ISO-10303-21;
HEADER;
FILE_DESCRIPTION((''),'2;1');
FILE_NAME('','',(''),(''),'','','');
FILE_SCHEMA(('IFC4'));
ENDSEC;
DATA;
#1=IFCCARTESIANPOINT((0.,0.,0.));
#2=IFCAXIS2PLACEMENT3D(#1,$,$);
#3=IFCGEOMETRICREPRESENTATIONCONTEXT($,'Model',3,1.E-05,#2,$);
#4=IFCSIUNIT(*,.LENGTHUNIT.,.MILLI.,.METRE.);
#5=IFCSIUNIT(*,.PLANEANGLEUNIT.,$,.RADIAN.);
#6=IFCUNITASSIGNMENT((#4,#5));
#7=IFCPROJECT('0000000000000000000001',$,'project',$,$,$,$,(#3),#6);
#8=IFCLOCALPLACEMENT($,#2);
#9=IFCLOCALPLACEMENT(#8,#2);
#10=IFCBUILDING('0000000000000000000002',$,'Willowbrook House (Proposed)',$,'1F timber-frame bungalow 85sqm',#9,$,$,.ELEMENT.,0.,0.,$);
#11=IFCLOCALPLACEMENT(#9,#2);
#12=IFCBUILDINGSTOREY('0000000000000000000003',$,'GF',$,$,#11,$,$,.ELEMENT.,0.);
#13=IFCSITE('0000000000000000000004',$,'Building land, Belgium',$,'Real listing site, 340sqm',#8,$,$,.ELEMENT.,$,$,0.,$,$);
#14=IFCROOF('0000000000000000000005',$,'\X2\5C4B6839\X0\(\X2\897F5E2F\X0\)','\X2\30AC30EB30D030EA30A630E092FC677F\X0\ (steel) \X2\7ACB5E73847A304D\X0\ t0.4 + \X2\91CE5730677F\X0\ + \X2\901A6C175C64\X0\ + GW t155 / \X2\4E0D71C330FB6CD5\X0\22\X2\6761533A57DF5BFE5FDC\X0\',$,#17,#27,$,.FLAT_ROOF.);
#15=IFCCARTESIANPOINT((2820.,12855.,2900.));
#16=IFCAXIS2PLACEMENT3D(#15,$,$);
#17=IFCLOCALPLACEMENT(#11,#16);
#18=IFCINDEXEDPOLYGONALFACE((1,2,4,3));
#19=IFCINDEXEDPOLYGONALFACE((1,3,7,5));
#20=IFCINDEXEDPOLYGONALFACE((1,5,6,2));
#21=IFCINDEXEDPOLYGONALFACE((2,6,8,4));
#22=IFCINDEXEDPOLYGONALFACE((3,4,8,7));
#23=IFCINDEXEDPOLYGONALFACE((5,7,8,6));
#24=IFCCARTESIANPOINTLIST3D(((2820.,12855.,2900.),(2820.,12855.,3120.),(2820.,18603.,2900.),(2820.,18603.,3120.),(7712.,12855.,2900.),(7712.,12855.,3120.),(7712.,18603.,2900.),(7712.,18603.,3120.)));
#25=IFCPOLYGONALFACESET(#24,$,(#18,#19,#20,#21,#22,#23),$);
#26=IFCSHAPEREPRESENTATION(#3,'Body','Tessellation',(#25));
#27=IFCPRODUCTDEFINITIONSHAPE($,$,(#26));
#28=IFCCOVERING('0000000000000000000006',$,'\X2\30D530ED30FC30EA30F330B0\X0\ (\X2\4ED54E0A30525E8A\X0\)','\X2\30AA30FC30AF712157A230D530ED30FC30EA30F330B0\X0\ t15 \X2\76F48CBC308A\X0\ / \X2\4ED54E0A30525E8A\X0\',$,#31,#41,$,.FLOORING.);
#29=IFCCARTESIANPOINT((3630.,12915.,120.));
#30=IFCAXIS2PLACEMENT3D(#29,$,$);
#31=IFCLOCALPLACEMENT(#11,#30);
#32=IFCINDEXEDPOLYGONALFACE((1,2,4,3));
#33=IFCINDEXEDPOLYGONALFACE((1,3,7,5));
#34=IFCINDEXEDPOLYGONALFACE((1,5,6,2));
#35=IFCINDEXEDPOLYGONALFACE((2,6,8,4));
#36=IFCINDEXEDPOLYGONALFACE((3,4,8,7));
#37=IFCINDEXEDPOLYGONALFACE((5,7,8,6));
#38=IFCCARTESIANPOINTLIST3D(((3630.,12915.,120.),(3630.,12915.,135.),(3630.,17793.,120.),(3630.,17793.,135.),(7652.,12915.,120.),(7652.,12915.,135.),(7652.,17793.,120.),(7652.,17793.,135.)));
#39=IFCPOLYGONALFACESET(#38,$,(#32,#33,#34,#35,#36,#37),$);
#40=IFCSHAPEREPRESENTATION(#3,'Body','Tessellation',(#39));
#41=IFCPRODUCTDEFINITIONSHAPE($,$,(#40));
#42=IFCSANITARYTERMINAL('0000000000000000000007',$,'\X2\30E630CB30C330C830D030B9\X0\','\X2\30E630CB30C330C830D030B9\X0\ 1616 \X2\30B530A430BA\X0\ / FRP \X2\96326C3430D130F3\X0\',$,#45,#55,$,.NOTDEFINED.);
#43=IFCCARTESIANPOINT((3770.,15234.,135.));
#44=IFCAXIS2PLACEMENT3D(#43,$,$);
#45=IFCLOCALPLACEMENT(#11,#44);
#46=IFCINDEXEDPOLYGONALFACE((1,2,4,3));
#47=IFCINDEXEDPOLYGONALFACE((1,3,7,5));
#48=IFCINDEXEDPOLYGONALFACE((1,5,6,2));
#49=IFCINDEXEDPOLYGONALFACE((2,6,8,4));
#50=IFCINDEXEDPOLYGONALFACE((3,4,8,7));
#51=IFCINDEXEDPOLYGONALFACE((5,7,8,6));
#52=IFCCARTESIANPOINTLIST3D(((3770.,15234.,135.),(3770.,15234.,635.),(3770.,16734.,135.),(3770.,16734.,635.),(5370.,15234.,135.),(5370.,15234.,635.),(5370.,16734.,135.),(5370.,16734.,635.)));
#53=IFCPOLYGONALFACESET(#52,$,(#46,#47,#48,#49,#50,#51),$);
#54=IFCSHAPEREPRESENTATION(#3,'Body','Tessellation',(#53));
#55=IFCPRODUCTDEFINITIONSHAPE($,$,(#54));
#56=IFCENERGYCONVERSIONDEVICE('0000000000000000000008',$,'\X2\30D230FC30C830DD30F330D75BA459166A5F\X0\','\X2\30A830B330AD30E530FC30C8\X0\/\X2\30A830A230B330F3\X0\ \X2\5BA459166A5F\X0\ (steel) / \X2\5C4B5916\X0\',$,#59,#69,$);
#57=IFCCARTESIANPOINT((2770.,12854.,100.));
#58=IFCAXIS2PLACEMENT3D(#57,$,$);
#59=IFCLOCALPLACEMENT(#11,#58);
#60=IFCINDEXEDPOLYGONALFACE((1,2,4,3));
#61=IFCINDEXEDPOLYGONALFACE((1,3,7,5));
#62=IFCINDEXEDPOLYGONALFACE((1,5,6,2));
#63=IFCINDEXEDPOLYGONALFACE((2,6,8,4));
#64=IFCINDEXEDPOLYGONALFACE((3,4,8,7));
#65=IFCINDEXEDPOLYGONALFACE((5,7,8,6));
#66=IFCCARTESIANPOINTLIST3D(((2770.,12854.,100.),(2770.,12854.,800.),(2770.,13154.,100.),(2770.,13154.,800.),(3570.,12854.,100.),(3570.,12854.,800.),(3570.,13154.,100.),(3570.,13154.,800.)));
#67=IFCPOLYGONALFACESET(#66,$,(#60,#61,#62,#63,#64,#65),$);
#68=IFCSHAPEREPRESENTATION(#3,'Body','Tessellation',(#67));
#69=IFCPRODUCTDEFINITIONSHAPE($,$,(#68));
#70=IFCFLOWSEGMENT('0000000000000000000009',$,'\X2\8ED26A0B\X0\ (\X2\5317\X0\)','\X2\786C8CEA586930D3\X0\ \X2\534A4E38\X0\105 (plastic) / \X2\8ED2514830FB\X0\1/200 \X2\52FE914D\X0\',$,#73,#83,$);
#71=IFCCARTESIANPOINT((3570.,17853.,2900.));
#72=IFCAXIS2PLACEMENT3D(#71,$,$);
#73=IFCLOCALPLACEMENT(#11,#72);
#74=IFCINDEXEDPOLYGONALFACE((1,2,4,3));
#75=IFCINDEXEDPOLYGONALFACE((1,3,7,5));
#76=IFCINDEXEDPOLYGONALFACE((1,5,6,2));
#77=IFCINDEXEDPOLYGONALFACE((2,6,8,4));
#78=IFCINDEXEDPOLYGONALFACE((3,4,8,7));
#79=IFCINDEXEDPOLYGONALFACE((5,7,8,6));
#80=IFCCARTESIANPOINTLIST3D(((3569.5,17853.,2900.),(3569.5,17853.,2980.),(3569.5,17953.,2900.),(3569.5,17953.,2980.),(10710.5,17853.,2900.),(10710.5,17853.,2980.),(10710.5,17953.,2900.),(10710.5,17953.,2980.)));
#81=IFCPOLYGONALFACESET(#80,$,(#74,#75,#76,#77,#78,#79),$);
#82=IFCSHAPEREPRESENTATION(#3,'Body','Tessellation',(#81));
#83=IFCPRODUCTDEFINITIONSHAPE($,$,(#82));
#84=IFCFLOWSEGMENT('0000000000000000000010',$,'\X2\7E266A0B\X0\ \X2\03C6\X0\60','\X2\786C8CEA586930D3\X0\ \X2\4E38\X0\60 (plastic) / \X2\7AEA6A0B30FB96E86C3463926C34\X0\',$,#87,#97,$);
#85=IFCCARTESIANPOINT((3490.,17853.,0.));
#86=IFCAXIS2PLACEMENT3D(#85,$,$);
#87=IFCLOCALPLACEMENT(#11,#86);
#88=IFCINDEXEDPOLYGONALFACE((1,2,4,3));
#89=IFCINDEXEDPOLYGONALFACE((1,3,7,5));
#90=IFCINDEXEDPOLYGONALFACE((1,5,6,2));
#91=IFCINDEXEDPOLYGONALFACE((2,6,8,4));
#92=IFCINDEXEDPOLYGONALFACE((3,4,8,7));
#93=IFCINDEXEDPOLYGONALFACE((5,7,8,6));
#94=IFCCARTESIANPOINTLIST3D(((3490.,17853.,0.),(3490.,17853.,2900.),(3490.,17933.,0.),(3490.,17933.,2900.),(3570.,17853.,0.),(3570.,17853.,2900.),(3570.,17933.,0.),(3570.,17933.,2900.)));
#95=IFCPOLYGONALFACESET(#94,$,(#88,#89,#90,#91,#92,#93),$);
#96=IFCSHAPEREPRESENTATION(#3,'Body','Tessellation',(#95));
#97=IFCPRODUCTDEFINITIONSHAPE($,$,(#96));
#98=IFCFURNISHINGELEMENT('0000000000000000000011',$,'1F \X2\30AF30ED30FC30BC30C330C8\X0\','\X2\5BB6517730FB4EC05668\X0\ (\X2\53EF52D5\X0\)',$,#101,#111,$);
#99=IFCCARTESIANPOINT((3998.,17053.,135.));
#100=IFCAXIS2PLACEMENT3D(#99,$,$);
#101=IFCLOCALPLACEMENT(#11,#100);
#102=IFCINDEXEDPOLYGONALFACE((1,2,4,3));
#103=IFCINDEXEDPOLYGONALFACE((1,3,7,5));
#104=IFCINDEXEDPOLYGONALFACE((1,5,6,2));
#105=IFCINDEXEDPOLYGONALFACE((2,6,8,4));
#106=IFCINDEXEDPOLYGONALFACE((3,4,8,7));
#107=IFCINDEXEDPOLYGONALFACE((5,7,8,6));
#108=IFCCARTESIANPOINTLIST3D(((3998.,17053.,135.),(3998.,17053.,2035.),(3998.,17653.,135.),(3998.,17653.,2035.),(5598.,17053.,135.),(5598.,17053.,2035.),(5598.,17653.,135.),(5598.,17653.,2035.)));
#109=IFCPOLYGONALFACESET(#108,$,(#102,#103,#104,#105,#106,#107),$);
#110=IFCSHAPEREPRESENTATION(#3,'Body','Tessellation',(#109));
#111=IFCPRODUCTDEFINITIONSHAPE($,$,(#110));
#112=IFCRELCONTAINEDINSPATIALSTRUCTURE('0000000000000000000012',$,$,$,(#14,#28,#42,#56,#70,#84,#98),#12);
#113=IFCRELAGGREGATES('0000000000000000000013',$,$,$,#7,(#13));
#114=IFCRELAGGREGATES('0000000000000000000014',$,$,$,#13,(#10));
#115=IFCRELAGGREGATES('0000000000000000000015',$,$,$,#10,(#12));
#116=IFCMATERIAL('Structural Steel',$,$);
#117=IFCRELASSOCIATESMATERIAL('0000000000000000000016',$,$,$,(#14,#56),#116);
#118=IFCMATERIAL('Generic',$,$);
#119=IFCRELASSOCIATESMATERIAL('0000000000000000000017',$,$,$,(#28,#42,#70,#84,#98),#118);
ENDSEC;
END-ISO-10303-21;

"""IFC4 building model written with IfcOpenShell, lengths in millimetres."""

from ifc_helpers import new_model, si_unit, frame, frame_2d, origin, place, context, project, spatial, rectangle, extrude, material, element, save


model = new_model("IFC4")

# Units and contexts
model_context = context("Model", 3, precision=1e-05, world=origin())
ifc_project = project(units=[si_unit("LENGTHUNIT", "METRE", prefix="MILLI"), si_unit("PLANEANGLEUNIT", "RADIAN")], contexts=[model_context])

# Site, building, storey
site_placement = place(None, origin())
site = spatial("IfcSite", under=ifc_project, at=site_placement, Name="Building land, Belgium", ObjectType="Real listing site, 340sqm", CompositionType="ELEMENT", RefElevation=0.0)
building_placement = place(site_placement, origin())
building = spatial("IfcBuilding", under=site, at=building_placement, Name="Willowbrook House (Proposed)", ObjectType="1F timber-frame bungalow 85sqm", CompositionType="ELEMENT", ElevationOfRefHeight=0.0, ElevationOfTerrain=0.0)
storey_placement = place(building_placement, origin())
storey = spatial("IfcBuildingStorey", under=building, at=storey_placement, Name="GF", CompositionType="ELEMENT", Elevation=0.0)

# Roof
ifc_material_1 = material(Name="Structural Steel")
roof_placement = place(storey_placement, frame((2820.0, 12855.0, 2900.0)))
element("IfcRoof", 1, at=roof_placement, inside=storey, material=ifc_material_1, Name="屋根(西帯)", Description="ガルバリウム鋼板 (steel) 立平葺き t0.4 + 野地板 + 通気層 + GW t155 / 不燃・法22条区域対応", PredefinedType="FLAT_ROOF", context=model_context, shape_type="SweptSolid", body=[
    extrude(rectangle(XDim=4892.0, YDim=5748.0, at=frame_2d((2446.0, 2874.0))), frame((2820.0, 12855.0, 2900.0)), (0.0, 0.0, 1.0), 220.0),
])

# Covering
ifc_material_2 = material(Name="Generic")
covering_placement = place(storey_placement, frame((3630.0, 12915.0, 120.0)))
element("IfcCovering", 2, at=covering_placement, inside=storey, material=ifc_material_2, Name="フローリング (仕上げ床)", Description="オーク無垢フローリング t15 直貼り / 仕上げ床", PredefinedType="FLOORING", context=model_context, shape_type="SweptSolid", body=[
    extrude(rectangle(XDim=4022.0, YDim=4878.0, at=frame_2d((2011.0, 2439.0))), frame((3630.0, 12915.0, 120.0)), (0.0, 0.0, 1.0), 15.0),
])

# Sanitary terminal
sanitary_terminal_placement = place(storey_placement, frame((3770.0, 15234.0, 135.0)))
element("IfcSanitaryTerminal", 3, at=sanitary_terminal_placement, inside=storey, material=ifc_material_2, Name="ユニットバス", Description="ユニットバス 1616 サイズ / FRP 防水パン", PredefinedType="NOTDEFINED", context=model_context, shape_type="SweptSolid", body=[
    extrude(rectangle(XDim=1600.0, YDim=1500.0, at=frame_2d((800.0, 750.0))), frame((3770.0, 15234.0, 135.0)), (0.0, 0.0, 1.0), 500.0),
])

# Energy conversion device
energy_conversion_device_placement = place(storey_placement, frame((2770.0, 12854.0, 100.0)))
element("IfcEnergyConversionDevice", 4, at=energy_conversion_device_placement, inside=storey, material=ifc_material_1, Name="ヒートポンプ室外機", Description="エコキュート/エアコン 室外機 (steel) / 屋外", context=model_context, shape_type="SweptSolid", body=[
    extrude(rectangle(XDim=800.0, YDim=300.0, at=frame_2d((400.0, 150.0))), frame((2770.0, 12854.0, 100.0)), (0.0, 0.0, 1.0), 700.0),
])

# Flow segments
flow_segment_1_placement = place(storey_placement, frame((3570.0, 17853.0, 2900.0)))
element("IfcFlowSegment", 5, at=flow_segment_1_placement, inside=storey, material=ifc_material_2, Name="軒樋 (北)", Description="硬質塩ビ 半丸105 (plastic) / 軒先・1/200 勾配", context=model_context, shape_type="SweptSolid", body=[
    extrude(rectangle(XDim=7141.0, YDim=100.0, at=frame_2d((3570.0, 50.0))), frame((3570.0, 17853.0, 2900.0)), (0.0, 0.0, 1.0), 80.0),
])
flow_segment_2_placement = place(storey_placement, frame((3490.0, 17853.0, 0.0)))
element("IfcFlowSegment", 6, at=flow_segment_2_placement, inside=storey, material=ifc_material_2, Name="縦樋 φ60", Description="硬質塩ビ 丸60 (plastic) / 竪樋・雨水排水", context=model_context, shape_type="SweptSolid", body=[
    extrude(rectangle(XDim=80.0, YDim=80.0, at=frame_2d((40.0, 40.0))), frame((3490.0, 17853.0, 0.0)), (0.0, 0.0, 1.0), 2900.0),
])

# Furnishing element
furnishing_placement = place(storey_placement, frame((3998.0, 17053.0, 135.0)))
element("IfcFurnishingElement", 7, at=furnishing_placement, inside=storey, material=ifc_material_2, Name="1F クローゼット", Description="家具・什器 (可動)", context=model_context, shape_type="SweptSolid", body=[
    extrude(rectangle(XDim=1600.0, YDim=600.0, at=frame_2d((800.0, 300.0))), frame((3998.0, 17053.0, 135.0)), (0.0, 0.0, 1.0), 1900.0),
])

save(model, "model.ifc")
